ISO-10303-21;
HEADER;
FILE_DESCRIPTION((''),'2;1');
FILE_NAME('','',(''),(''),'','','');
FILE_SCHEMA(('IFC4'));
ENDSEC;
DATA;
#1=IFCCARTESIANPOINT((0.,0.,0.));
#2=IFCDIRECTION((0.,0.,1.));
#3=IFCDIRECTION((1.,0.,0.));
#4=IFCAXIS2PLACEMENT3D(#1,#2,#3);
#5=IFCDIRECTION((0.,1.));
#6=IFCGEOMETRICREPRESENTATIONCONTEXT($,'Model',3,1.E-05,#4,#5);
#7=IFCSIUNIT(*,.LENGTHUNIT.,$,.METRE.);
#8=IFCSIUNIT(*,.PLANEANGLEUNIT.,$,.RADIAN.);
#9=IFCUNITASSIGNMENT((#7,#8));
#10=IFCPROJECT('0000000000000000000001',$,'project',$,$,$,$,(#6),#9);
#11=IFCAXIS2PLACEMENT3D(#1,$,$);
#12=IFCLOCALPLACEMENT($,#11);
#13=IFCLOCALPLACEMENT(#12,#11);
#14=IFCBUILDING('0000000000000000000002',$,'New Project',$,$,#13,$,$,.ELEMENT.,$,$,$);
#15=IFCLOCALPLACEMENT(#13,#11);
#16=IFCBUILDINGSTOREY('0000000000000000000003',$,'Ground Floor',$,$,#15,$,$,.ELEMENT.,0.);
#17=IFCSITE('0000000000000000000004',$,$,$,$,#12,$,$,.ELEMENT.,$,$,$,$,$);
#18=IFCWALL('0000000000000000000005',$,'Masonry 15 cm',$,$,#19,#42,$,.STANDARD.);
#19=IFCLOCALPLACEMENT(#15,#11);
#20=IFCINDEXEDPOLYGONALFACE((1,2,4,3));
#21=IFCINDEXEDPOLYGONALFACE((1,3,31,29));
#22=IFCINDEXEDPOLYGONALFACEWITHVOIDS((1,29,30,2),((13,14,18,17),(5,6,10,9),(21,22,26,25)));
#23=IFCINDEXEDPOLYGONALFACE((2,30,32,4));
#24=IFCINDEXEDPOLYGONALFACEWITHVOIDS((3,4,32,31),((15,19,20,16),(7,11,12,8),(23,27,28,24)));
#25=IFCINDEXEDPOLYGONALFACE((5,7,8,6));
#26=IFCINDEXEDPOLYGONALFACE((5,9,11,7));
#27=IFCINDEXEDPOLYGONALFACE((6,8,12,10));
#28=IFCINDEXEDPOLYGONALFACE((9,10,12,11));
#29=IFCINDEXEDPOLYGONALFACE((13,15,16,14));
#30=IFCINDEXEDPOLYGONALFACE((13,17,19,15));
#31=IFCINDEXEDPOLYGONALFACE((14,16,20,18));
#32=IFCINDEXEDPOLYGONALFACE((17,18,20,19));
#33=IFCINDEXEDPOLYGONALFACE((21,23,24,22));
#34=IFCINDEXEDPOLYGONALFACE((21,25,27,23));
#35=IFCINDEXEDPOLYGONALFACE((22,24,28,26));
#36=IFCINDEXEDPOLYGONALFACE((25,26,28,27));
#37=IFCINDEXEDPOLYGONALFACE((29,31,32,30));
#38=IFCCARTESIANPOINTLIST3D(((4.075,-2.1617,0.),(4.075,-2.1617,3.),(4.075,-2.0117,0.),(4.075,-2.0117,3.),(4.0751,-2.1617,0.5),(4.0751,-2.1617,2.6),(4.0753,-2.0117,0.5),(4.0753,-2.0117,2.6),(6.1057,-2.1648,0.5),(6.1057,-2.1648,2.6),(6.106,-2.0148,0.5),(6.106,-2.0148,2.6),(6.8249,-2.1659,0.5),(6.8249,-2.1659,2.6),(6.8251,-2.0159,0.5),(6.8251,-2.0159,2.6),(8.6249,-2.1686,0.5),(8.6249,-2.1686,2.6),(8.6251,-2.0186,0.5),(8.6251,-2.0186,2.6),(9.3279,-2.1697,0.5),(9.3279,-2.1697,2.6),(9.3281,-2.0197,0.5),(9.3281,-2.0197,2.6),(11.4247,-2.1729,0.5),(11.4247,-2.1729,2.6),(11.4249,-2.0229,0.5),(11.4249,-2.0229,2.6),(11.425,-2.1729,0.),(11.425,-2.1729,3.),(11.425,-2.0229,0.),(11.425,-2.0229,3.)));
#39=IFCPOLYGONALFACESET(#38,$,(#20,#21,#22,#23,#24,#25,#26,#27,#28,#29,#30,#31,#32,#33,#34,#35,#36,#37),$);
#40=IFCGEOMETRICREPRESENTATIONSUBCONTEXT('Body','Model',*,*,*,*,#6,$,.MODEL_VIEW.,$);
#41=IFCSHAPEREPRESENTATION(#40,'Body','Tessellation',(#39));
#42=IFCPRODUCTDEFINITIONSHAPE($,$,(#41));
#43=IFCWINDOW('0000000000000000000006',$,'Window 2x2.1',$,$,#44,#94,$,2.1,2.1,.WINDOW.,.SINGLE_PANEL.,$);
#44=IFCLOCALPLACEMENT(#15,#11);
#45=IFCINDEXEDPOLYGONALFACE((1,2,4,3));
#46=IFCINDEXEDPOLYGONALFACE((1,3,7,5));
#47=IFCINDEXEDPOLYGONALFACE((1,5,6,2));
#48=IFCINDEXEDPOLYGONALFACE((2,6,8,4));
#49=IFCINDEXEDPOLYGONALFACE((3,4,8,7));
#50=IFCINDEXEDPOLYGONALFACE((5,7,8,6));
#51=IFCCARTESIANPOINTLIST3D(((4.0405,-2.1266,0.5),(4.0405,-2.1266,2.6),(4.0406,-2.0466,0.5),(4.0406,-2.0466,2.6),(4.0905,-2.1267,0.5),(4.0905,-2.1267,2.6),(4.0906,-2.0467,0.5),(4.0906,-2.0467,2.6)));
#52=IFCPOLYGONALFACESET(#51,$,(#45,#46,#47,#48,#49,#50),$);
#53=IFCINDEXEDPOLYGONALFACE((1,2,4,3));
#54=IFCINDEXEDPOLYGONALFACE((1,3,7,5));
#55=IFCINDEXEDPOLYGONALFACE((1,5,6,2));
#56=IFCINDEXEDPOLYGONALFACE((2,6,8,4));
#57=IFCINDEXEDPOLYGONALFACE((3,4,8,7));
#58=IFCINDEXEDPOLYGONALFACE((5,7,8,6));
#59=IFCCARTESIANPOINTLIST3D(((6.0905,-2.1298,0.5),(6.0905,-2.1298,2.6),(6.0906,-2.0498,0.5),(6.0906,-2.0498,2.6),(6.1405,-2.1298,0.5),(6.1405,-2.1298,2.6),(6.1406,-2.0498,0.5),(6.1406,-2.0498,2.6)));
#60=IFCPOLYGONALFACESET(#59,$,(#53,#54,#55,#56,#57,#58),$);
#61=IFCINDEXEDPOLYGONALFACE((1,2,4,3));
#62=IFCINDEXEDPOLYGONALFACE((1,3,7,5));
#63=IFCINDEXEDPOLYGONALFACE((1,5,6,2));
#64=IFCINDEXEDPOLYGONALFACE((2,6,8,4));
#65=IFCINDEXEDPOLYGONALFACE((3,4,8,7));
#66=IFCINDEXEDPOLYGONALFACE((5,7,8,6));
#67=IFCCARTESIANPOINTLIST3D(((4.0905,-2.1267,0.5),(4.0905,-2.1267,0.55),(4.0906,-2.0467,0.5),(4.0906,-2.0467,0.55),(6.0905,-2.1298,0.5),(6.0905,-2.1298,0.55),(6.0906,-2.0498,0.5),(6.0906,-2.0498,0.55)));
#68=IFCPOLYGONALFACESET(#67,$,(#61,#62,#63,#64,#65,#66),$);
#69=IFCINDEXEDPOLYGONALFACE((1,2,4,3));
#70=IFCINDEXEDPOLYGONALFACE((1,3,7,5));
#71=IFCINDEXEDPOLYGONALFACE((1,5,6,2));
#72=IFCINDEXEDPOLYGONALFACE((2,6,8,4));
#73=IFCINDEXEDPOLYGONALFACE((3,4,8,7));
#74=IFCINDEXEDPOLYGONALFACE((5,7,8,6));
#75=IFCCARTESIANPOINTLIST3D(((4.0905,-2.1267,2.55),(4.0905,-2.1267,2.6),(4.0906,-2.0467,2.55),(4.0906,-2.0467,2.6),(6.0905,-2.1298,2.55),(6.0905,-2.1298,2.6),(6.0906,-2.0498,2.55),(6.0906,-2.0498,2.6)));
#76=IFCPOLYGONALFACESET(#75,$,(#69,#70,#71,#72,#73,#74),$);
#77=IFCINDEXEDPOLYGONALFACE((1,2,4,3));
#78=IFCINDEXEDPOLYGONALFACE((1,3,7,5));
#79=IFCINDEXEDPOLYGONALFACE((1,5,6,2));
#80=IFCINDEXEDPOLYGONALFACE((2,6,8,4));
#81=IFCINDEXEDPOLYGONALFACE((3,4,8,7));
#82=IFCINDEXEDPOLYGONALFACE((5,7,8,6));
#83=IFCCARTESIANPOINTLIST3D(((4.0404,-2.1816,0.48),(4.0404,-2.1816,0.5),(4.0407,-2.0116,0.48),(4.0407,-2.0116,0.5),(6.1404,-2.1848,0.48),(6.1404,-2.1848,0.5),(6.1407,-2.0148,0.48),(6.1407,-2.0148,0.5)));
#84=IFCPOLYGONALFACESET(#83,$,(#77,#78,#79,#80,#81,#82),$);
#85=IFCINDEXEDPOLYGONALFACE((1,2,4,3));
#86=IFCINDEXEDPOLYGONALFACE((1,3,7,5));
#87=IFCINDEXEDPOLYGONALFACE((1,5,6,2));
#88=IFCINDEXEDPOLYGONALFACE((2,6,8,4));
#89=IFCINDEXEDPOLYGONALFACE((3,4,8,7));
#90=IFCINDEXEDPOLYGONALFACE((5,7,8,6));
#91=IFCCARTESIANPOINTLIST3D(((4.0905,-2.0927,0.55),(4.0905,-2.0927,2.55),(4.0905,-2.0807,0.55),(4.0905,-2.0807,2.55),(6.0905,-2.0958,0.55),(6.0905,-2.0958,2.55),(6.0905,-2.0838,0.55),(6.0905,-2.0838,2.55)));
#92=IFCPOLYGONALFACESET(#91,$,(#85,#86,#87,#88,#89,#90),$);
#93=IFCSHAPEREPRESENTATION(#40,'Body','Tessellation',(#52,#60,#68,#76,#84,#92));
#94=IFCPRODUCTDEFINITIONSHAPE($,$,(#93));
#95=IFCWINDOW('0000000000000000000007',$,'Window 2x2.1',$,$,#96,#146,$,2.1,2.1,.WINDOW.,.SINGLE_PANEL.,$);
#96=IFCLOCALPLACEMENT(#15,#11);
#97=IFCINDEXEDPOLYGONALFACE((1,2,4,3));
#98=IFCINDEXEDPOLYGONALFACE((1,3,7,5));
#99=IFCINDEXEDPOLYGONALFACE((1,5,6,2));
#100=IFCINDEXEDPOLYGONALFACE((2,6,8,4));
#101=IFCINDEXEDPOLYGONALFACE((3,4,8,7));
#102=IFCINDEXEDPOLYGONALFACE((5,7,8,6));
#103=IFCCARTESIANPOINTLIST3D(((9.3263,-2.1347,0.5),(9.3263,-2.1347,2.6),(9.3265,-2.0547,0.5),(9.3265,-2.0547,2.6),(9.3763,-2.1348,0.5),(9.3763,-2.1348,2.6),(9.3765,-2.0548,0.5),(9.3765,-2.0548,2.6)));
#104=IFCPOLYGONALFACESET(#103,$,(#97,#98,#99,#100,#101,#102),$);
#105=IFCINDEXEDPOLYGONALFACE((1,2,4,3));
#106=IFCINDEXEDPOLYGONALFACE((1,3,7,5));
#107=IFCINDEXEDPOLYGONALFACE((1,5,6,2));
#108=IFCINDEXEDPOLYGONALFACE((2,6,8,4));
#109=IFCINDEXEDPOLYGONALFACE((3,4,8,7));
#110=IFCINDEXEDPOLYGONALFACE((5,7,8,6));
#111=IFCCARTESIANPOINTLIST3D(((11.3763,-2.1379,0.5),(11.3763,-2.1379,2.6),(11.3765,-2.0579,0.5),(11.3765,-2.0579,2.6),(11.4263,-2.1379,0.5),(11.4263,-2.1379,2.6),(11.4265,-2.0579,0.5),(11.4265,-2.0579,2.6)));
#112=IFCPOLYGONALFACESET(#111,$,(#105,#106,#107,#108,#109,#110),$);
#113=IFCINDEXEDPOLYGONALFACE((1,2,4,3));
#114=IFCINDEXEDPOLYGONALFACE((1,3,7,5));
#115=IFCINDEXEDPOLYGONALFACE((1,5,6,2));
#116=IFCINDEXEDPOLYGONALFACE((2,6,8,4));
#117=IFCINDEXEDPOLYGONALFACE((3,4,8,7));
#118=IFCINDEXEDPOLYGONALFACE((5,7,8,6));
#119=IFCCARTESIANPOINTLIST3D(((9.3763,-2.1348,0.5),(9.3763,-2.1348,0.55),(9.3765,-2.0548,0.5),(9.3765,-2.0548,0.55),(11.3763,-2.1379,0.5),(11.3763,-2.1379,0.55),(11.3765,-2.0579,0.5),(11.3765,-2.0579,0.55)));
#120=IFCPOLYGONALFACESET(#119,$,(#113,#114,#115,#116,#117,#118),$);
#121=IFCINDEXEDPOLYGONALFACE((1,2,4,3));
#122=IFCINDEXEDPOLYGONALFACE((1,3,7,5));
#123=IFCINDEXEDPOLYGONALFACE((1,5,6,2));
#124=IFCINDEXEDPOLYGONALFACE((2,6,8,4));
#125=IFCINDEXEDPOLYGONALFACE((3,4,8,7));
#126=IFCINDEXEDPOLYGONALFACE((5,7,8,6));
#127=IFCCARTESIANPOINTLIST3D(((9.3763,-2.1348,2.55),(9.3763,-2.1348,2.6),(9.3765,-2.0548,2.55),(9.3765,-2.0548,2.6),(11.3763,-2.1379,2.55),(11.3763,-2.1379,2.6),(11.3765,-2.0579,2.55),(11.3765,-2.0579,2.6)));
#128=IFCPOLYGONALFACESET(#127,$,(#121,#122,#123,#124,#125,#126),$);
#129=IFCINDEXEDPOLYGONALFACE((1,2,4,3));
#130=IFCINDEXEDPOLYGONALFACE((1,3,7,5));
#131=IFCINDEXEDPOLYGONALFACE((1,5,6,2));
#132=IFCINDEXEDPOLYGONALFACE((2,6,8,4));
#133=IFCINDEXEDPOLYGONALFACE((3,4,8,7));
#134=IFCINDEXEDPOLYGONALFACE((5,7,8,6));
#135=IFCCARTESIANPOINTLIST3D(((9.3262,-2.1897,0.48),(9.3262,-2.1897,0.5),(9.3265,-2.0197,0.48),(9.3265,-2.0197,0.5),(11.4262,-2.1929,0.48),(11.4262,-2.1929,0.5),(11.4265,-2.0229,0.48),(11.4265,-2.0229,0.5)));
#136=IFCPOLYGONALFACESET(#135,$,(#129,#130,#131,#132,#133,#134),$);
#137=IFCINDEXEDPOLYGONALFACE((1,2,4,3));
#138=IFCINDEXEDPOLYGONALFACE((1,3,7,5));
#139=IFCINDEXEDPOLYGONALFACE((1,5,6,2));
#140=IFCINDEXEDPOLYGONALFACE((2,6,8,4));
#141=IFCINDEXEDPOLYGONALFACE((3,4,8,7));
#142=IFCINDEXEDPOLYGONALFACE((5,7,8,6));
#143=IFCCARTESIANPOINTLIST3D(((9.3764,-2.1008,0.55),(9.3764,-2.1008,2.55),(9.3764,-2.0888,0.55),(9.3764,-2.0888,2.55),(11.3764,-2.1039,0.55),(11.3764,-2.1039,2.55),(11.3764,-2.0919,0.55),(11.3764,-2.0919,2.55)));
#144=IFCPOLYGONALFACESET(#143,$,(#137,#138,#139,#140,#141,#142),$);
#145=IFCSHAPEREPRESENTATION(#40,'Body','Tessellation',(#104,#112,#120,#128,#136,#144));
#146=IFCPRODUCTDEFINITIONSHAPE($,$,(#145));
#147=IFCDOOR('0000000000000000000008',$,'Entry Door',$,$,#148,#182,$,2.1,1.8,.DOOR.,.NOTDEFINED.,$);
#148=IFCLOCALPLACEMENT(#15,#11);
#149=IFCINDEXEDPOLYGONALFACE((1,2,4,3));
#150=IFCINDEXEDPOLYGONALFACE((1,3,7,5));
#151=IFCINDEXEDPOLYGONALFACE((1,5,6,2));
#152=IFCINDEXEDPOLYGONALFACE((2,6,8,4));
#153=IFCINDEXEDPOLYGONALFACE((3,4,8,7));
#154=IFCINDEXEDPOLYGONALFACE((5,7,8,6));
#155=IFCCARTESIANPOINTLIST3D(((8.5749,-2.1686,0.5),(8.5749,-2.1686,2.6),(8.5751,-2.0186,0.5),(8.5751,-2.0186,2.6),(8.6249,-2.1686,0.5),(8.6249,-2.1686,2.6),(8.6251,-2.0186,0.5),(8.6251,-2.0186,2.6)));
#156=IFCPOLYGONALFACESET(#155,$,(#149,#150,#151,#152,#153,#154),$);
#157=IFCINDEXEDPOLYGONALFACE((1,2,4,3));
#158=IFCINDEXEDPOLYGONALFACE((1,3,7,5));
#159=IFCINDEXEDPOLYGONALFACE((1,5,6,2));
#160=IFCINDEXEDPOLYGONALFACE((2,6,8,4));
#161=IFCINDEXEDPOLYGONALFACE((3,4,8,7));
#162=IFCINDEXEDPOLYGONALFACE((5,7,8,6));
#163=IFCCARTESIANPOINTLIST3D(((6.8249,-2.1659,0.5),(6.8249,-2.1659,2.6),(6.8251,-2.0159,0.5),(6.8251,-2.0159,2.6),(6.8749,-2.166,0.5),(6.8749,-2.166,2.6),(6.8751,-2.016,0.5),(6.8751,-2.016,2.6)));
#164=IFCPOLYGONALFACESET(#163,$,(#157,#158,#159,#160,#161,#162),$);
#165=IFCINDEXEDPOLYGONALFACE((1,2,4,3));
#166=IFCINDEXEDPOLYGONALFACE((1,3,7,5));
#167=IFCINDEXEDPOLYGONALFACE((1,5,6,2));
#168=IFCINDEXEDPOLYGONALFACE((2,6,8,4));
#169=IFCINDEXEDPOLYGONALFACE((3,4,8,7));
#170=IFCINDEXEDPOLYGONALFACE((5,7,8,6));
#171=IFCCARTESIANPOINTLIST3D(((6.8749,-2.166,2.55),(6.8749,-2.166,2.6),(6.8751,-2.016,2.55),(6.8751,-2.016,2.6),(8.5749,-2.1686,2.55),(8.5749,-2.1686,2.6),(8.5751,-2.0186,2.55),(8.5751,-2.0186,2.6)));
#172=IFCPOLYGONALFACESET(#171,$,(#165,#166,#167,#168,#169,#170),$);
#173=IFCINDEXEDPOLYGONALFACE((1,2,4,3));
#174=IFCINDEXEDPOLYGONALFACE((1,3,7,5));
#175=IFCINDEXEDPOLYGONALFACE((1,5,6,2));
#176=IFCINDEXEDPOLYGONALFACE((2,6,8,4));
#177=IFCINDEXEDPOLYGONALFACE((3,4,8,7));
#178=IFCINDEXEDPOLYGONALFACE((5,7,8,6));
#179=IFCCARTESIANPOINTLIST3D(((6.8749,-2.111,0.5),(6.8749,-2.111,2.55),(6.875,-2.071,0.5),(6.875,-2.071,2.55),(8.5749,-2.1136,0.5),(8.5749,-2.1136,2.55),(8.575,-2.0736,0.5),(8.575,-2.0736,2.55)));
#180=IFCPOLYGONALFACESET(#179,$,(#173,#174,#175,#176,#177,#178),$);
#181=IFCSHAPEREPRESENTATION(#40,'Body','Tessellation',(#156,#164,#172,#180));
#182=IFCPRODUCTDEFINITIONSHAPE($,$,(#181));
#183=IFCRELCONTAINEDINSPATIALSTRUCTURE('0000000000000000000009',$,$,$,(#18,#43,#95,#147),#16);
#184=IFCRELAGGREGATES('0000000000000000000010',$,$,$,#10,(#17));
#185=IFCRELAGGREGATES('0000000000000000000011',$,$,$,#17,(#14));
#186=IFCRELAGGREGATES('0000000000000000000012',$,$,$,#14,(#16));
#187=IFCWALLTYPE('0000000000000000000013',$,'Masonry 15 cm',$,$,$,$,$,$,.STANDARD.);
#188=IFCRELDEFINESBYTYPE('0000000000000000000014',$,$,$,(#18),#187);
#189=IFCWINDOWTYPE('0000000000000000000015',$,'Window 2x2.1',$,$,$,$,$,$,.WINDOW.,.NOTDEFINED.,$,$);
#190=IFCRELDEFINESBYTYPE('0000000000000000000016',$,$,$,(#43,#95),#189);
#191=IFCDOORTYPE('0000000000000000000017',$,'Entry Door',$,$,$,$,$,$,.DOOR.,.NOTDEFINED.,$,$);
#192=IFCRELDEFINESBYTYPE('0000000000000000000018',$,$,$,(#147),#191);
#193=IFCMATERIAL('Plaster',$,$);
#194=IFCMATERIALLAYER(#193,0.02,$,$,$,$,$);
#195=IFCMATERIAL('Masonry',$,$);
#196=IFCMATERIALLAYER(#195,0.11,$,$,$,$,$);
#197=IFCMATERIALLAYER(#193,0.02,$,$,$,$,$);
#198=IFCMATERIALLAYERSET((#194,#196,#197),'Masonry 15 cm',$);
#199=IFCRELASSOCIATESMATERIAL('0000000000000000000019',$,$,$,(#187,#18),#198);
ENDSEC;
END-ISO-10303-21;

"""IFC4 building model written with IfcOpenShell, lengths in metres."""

from ifc_helpers import new_model, si_unit, direction, frame, frame_2d, origin, origin_with_axes, place, context, subcontext, project, spatial, polyline, rectangle, outline, extrude, material, layer, layer_set, layer_usage, type_object, element, fill, save


model = new_model("IFC4")

# Units and contexts
model_context = context("Model", 3, precision=1e-05, world=origin_with_axes(), true_north=direction((0.0, 1.0)))
body_context = subcontext(model_context, "Body", "Model", "MODEL_VIEW")
ifc_project = project(units=[si_unit("LENGTHUNIT", "METRE"), si_unit("PLANEANGLEUNIT", "RADIAN")], contexts=[model_context])

# Site, building, storey
site_placement = place(None, origin())
site = spatial("IfcSite", under=ifc_project, at=site_placement, CompositionType="ELEMENT")
building_placement = place(site_placement, origin())
building = spatial("IfcBuilding", under=site, at=building_placement, Name="New Project", CompositionType="ELEMENT")
storey_placement = place(building_placement, origin())
storey = spatial("IfcBuildingStorey", under=building, at=storey_placement, Name="Ground Floor", CompositionType="ELEMENT", Elevation=0.0)

# Shared definitions
ifc_material_1 = material(Name="Plaster")
ifc_layer_1 = layer(ifc_material_1, 0.02)
ifc_material_2 = material(Name="Masonry")
ifc_layer_2 = layer(ifc_material_2, 0.11)
ifc_layer_3 = layer(ifc_material_1, 0.02)
ifc_layer_set_1 = layer_set([ifc_layer_1, ifc_layer_2, ifc_layer_3], Name="Masonry 15 cm")
ifc_layer_usage_1 = layer_usage(ifc_layer_set_1, "AXIS2", "NEGATIVE", 0.075)
wall_type_1 = type_object("IfcWallType", Name="Masonry 15 cm", PredefinedType="STANDARD", material=ifc_layer_set_1)

# Wall, openings, windows, door
wall_1_placement = place(storey_placement, frame((11.425, -2.0979, 0.0), z_axis=(0.0, 0.0, 1.0), x_axis=(-0.999999, 0.001534, 0.0)))
wall_1 = element("IfcWall", 1, at=wall_1_placement, inside=storey, type_object=wall_type_1, material=ifc_layer_usage_1, Name="Masonry 15 cm", PredefinedType="STANDARD", context=body_context, shape_type="SweptSolid", body=[
    extrude(outline(polyline([(0.0001, -0.075), (7.3501, -0.075), (7.3499, 0.075), (-0.0001, 0.075), (0.0001, -0.075)])), origin(), (0.0, 0.0, 1.0), 3.0),
])
opening_1_placement = place(wall_1_placement, frame((5.3191, 0.0, 0.5)))
opening_1 = element("IfcOpeningElement", 2, at=opening_1_placement, cuts=wall_1, PredefinedType="OPENING", context=body_context, shape_type="SweptSolid", body=[
    extrude(rectangle(XDim=2.0306, YDim=0.25, at=frame_2d((1.0153, 0.0))), origin(), (0.0, 0.0, 1.0), 2.1),
])
opening_2_placement = place(wall_1_placement, frame((2.8, 0.0, 0.5)))
opening_2 = element("IfcOpeningElement", 3, at=opening_2_placement, cuts=wall_1, PredefinedType="OPENING", context=body_context, shape_type="SweptSolid", body=[
    extrude(rectangle(XDim=1.8, YDim=0.25, at=frame_2d((0.9, 0.0))), origin(), (0.0, 0.0, 1.0), 2.1),
])
opening_3_placement = place(wall_1_placement, frame((0.0002, 0.0, 0.5)))
opening_3 = element("IfcOpeningElement", 4, at=opening_3_placement, cuts=wall_1, PredefinedType="OPENING", context=body_context, shape_type="SweptSolid", body=[
    extrude(rectangle(XDim=2.0968, YDim=0.25, at=frame_2d((1.0484, 0.0))), origin(), (0.0, 0.0, 1.0), 2.1),
])
window_type_1 = type_object("IfcWindowType", Name="Window 2x2.1", PartitioningType="NOTDEFINED", PredefinedType="WINDOW")
window_1_placement = place(opening_1_placement, origin())
window_1 = element("IfcWindow", 5, at=window_1_placement, inside=storey, type_object=window_type_1, Name="Window 2x2.1", OverallHeight=2.1, OverallWidth=2.1, PartitioningType="SINGLE_PANEL", PredefinedType="WINDOW", context=body_context, shape_type="SweptSolid", body=[
    extrude(outline(polyline([(2.0653, 0.04), (2.0153, 0.04), (2.0153, -0.04), (2.0653, -0.04), (2.0653, 0.04)])), origin(), (0.0, 0.0, 1.0), 2.1),
    extrude(outline(polyline([(0.0153, 0.04), (-0.0347, 0.04), (-0.0347, -0.04), (0.0153, -0.04), (0.0153, 0.04)])), origin(), (0.0, 0.0, 1.0), 2.1),
    extrude(outline(polyline([(2.0153, 0.04), (0.0153, 0.04), (0.0153, -0.04), (2.0153, -0.04), (2.0153, 0.04)])), origin(), (0.0, 0.0, 1.0), 0.05),
    extrude(outline(polyline([(2.0153, 0.04), (0.0153, 0.04), (0.0153, -0.04), (2.0153, -0.04), (2.0153, 0.04)])), frame((0.0, 0.0, 2.05)), (0.0, 0.0, 1.0), 0.05),
    extrude(outline(polyline([(2.0653, 0.095), (-0.0347, 0.095), (-0.0347, -0.075), (2.0653, -0.075), (2.0653, 0.095)])), frame((0.0, 0.0, -0.02)), (0.0, 0.0, 1.0), 0.02),
    extrude(outline(polyline([(2.0153, 0.006), (0.0153, 0.006), (0.0153, -0.006), (2.0153, -0.006), (2.0153, 0.006)])), frame((0.0, 0.0, 0.05)), (0.0, 0.0, 1.0), 2.0),
])
fill(opening_1, window_1)
window_2_placement = place(opening_3_placement, origin())
window_2 = element("IfcWindow", 6, at=window_2_placement, inside=storey, type_object=window_type_1, Name="Window 2x2.1", OverallHeight=2.1, OverallWidth=2.1, PartitioningType="SINGLE_PANEL", PredefinedType="WINDOW", context=body_context, shape_type="SweptSolid", body=[
    extrude(outline(polyline([(2.0984, 0.04), (2.0484, 0.04), (2.0484, -0.04), (2.0984, -0.04), (2.0984, 0.04)])), origin(), (0.0, 0.0, 1.0), 2.1),
    extrude(outline(polyline([(0.0484, 0.04), (-0.0016, 0.04), (-0.0016, -0.04), (0.0484, -0.04), (0.0484, 0.04)])), origin(), (0.0, 0.0, 1.0), 2.1),
    extrude(outline(polyline([(2.0484, 0.04), (0.0484, 0.04), (0.0484, -0.04), (2.0484, -0.04), (2.0484, 0.04)])), origin(), (0.0, 0.0, 1.0), 0.05),
    extrude(outline(polyline([(2.0484, 0.04), (0.0484, 0.04), (0.0484, -0.04), (2.0484, -0.04), (2.0484, 0.04)])), frame((0.0, 0.0, 2.05)), (0.0, 0.0, 1.0), 0.05),
    extrude(outline(polyline([(2.0984, 0.095), (-0.0016, 0.095), (-0.0016, -0.075), (2.0984, -0.075), (2.0984, 0.095)])), frame((0.0, 0.0, -0.02)), (0.0, 0.0, 1.0), 0.02),
    extrude(outline(polyline([(2.0484, 0.006), (0.0484, 0.006), (0.0484, -0.006), (2.0484, -0.006), (2.0484, 0.006)])), frame((0.0, 0.0, 0.05)), (0.0, 0.0, 1.0), 2.0),
])
fill(opening_3, window_2)
door_type = type_object("IfcDoorType", Name="Entry Door", OperationType="NOTDEFINED", PredefinedType="DOOR")
door_placement = place(opening_2_placement, origin())
door = element("IfcDoor", 7, at=door_placement, inside=storey, type_object=door_type, Name="Entry Door", OperationType="NOTDEFINED", OverallHeight=2.1, OverallWidth=1.8, PredefinedType="DOOR", context=body_context, shape_type="SweptSolid", body=[
    extrude(outline(polyline([(0.0, -0.075), (0.05, -0.075), (0.05, 0.075), (0.0, 0.075), (0.0, -0.075)])), origin(), (0.0, 0.0, 1.0), 2.1),
    extrude(outline(polyline([(1.75, -0.075), (1.8, -0.075), (1.8, 0.075), (1.75, 0.075), (1.75, -0.075)])), origin(), (0.0, 0.0, 1.0), 2.1),
    extrude(outline(polyline([(0.05, -0.075), (1.75, -0.075), (1.75, 0.075), (0.05, 0.075), (0.05, -0.075)])), frame((0.0, 0.0, 2.05)), (0.0, 0.0, 1.0), 0.05),
    extrude(outline(polyline([(0.05, -0.02), (1.75, -0.02), (1.75, 0.02), (0.05, 0.02), (0.05, -0.02)])), origin(), (0.0, 0.0, 1.0), 2.05),
])
fill(opening_2, door)

save(model, "model.ifc")
